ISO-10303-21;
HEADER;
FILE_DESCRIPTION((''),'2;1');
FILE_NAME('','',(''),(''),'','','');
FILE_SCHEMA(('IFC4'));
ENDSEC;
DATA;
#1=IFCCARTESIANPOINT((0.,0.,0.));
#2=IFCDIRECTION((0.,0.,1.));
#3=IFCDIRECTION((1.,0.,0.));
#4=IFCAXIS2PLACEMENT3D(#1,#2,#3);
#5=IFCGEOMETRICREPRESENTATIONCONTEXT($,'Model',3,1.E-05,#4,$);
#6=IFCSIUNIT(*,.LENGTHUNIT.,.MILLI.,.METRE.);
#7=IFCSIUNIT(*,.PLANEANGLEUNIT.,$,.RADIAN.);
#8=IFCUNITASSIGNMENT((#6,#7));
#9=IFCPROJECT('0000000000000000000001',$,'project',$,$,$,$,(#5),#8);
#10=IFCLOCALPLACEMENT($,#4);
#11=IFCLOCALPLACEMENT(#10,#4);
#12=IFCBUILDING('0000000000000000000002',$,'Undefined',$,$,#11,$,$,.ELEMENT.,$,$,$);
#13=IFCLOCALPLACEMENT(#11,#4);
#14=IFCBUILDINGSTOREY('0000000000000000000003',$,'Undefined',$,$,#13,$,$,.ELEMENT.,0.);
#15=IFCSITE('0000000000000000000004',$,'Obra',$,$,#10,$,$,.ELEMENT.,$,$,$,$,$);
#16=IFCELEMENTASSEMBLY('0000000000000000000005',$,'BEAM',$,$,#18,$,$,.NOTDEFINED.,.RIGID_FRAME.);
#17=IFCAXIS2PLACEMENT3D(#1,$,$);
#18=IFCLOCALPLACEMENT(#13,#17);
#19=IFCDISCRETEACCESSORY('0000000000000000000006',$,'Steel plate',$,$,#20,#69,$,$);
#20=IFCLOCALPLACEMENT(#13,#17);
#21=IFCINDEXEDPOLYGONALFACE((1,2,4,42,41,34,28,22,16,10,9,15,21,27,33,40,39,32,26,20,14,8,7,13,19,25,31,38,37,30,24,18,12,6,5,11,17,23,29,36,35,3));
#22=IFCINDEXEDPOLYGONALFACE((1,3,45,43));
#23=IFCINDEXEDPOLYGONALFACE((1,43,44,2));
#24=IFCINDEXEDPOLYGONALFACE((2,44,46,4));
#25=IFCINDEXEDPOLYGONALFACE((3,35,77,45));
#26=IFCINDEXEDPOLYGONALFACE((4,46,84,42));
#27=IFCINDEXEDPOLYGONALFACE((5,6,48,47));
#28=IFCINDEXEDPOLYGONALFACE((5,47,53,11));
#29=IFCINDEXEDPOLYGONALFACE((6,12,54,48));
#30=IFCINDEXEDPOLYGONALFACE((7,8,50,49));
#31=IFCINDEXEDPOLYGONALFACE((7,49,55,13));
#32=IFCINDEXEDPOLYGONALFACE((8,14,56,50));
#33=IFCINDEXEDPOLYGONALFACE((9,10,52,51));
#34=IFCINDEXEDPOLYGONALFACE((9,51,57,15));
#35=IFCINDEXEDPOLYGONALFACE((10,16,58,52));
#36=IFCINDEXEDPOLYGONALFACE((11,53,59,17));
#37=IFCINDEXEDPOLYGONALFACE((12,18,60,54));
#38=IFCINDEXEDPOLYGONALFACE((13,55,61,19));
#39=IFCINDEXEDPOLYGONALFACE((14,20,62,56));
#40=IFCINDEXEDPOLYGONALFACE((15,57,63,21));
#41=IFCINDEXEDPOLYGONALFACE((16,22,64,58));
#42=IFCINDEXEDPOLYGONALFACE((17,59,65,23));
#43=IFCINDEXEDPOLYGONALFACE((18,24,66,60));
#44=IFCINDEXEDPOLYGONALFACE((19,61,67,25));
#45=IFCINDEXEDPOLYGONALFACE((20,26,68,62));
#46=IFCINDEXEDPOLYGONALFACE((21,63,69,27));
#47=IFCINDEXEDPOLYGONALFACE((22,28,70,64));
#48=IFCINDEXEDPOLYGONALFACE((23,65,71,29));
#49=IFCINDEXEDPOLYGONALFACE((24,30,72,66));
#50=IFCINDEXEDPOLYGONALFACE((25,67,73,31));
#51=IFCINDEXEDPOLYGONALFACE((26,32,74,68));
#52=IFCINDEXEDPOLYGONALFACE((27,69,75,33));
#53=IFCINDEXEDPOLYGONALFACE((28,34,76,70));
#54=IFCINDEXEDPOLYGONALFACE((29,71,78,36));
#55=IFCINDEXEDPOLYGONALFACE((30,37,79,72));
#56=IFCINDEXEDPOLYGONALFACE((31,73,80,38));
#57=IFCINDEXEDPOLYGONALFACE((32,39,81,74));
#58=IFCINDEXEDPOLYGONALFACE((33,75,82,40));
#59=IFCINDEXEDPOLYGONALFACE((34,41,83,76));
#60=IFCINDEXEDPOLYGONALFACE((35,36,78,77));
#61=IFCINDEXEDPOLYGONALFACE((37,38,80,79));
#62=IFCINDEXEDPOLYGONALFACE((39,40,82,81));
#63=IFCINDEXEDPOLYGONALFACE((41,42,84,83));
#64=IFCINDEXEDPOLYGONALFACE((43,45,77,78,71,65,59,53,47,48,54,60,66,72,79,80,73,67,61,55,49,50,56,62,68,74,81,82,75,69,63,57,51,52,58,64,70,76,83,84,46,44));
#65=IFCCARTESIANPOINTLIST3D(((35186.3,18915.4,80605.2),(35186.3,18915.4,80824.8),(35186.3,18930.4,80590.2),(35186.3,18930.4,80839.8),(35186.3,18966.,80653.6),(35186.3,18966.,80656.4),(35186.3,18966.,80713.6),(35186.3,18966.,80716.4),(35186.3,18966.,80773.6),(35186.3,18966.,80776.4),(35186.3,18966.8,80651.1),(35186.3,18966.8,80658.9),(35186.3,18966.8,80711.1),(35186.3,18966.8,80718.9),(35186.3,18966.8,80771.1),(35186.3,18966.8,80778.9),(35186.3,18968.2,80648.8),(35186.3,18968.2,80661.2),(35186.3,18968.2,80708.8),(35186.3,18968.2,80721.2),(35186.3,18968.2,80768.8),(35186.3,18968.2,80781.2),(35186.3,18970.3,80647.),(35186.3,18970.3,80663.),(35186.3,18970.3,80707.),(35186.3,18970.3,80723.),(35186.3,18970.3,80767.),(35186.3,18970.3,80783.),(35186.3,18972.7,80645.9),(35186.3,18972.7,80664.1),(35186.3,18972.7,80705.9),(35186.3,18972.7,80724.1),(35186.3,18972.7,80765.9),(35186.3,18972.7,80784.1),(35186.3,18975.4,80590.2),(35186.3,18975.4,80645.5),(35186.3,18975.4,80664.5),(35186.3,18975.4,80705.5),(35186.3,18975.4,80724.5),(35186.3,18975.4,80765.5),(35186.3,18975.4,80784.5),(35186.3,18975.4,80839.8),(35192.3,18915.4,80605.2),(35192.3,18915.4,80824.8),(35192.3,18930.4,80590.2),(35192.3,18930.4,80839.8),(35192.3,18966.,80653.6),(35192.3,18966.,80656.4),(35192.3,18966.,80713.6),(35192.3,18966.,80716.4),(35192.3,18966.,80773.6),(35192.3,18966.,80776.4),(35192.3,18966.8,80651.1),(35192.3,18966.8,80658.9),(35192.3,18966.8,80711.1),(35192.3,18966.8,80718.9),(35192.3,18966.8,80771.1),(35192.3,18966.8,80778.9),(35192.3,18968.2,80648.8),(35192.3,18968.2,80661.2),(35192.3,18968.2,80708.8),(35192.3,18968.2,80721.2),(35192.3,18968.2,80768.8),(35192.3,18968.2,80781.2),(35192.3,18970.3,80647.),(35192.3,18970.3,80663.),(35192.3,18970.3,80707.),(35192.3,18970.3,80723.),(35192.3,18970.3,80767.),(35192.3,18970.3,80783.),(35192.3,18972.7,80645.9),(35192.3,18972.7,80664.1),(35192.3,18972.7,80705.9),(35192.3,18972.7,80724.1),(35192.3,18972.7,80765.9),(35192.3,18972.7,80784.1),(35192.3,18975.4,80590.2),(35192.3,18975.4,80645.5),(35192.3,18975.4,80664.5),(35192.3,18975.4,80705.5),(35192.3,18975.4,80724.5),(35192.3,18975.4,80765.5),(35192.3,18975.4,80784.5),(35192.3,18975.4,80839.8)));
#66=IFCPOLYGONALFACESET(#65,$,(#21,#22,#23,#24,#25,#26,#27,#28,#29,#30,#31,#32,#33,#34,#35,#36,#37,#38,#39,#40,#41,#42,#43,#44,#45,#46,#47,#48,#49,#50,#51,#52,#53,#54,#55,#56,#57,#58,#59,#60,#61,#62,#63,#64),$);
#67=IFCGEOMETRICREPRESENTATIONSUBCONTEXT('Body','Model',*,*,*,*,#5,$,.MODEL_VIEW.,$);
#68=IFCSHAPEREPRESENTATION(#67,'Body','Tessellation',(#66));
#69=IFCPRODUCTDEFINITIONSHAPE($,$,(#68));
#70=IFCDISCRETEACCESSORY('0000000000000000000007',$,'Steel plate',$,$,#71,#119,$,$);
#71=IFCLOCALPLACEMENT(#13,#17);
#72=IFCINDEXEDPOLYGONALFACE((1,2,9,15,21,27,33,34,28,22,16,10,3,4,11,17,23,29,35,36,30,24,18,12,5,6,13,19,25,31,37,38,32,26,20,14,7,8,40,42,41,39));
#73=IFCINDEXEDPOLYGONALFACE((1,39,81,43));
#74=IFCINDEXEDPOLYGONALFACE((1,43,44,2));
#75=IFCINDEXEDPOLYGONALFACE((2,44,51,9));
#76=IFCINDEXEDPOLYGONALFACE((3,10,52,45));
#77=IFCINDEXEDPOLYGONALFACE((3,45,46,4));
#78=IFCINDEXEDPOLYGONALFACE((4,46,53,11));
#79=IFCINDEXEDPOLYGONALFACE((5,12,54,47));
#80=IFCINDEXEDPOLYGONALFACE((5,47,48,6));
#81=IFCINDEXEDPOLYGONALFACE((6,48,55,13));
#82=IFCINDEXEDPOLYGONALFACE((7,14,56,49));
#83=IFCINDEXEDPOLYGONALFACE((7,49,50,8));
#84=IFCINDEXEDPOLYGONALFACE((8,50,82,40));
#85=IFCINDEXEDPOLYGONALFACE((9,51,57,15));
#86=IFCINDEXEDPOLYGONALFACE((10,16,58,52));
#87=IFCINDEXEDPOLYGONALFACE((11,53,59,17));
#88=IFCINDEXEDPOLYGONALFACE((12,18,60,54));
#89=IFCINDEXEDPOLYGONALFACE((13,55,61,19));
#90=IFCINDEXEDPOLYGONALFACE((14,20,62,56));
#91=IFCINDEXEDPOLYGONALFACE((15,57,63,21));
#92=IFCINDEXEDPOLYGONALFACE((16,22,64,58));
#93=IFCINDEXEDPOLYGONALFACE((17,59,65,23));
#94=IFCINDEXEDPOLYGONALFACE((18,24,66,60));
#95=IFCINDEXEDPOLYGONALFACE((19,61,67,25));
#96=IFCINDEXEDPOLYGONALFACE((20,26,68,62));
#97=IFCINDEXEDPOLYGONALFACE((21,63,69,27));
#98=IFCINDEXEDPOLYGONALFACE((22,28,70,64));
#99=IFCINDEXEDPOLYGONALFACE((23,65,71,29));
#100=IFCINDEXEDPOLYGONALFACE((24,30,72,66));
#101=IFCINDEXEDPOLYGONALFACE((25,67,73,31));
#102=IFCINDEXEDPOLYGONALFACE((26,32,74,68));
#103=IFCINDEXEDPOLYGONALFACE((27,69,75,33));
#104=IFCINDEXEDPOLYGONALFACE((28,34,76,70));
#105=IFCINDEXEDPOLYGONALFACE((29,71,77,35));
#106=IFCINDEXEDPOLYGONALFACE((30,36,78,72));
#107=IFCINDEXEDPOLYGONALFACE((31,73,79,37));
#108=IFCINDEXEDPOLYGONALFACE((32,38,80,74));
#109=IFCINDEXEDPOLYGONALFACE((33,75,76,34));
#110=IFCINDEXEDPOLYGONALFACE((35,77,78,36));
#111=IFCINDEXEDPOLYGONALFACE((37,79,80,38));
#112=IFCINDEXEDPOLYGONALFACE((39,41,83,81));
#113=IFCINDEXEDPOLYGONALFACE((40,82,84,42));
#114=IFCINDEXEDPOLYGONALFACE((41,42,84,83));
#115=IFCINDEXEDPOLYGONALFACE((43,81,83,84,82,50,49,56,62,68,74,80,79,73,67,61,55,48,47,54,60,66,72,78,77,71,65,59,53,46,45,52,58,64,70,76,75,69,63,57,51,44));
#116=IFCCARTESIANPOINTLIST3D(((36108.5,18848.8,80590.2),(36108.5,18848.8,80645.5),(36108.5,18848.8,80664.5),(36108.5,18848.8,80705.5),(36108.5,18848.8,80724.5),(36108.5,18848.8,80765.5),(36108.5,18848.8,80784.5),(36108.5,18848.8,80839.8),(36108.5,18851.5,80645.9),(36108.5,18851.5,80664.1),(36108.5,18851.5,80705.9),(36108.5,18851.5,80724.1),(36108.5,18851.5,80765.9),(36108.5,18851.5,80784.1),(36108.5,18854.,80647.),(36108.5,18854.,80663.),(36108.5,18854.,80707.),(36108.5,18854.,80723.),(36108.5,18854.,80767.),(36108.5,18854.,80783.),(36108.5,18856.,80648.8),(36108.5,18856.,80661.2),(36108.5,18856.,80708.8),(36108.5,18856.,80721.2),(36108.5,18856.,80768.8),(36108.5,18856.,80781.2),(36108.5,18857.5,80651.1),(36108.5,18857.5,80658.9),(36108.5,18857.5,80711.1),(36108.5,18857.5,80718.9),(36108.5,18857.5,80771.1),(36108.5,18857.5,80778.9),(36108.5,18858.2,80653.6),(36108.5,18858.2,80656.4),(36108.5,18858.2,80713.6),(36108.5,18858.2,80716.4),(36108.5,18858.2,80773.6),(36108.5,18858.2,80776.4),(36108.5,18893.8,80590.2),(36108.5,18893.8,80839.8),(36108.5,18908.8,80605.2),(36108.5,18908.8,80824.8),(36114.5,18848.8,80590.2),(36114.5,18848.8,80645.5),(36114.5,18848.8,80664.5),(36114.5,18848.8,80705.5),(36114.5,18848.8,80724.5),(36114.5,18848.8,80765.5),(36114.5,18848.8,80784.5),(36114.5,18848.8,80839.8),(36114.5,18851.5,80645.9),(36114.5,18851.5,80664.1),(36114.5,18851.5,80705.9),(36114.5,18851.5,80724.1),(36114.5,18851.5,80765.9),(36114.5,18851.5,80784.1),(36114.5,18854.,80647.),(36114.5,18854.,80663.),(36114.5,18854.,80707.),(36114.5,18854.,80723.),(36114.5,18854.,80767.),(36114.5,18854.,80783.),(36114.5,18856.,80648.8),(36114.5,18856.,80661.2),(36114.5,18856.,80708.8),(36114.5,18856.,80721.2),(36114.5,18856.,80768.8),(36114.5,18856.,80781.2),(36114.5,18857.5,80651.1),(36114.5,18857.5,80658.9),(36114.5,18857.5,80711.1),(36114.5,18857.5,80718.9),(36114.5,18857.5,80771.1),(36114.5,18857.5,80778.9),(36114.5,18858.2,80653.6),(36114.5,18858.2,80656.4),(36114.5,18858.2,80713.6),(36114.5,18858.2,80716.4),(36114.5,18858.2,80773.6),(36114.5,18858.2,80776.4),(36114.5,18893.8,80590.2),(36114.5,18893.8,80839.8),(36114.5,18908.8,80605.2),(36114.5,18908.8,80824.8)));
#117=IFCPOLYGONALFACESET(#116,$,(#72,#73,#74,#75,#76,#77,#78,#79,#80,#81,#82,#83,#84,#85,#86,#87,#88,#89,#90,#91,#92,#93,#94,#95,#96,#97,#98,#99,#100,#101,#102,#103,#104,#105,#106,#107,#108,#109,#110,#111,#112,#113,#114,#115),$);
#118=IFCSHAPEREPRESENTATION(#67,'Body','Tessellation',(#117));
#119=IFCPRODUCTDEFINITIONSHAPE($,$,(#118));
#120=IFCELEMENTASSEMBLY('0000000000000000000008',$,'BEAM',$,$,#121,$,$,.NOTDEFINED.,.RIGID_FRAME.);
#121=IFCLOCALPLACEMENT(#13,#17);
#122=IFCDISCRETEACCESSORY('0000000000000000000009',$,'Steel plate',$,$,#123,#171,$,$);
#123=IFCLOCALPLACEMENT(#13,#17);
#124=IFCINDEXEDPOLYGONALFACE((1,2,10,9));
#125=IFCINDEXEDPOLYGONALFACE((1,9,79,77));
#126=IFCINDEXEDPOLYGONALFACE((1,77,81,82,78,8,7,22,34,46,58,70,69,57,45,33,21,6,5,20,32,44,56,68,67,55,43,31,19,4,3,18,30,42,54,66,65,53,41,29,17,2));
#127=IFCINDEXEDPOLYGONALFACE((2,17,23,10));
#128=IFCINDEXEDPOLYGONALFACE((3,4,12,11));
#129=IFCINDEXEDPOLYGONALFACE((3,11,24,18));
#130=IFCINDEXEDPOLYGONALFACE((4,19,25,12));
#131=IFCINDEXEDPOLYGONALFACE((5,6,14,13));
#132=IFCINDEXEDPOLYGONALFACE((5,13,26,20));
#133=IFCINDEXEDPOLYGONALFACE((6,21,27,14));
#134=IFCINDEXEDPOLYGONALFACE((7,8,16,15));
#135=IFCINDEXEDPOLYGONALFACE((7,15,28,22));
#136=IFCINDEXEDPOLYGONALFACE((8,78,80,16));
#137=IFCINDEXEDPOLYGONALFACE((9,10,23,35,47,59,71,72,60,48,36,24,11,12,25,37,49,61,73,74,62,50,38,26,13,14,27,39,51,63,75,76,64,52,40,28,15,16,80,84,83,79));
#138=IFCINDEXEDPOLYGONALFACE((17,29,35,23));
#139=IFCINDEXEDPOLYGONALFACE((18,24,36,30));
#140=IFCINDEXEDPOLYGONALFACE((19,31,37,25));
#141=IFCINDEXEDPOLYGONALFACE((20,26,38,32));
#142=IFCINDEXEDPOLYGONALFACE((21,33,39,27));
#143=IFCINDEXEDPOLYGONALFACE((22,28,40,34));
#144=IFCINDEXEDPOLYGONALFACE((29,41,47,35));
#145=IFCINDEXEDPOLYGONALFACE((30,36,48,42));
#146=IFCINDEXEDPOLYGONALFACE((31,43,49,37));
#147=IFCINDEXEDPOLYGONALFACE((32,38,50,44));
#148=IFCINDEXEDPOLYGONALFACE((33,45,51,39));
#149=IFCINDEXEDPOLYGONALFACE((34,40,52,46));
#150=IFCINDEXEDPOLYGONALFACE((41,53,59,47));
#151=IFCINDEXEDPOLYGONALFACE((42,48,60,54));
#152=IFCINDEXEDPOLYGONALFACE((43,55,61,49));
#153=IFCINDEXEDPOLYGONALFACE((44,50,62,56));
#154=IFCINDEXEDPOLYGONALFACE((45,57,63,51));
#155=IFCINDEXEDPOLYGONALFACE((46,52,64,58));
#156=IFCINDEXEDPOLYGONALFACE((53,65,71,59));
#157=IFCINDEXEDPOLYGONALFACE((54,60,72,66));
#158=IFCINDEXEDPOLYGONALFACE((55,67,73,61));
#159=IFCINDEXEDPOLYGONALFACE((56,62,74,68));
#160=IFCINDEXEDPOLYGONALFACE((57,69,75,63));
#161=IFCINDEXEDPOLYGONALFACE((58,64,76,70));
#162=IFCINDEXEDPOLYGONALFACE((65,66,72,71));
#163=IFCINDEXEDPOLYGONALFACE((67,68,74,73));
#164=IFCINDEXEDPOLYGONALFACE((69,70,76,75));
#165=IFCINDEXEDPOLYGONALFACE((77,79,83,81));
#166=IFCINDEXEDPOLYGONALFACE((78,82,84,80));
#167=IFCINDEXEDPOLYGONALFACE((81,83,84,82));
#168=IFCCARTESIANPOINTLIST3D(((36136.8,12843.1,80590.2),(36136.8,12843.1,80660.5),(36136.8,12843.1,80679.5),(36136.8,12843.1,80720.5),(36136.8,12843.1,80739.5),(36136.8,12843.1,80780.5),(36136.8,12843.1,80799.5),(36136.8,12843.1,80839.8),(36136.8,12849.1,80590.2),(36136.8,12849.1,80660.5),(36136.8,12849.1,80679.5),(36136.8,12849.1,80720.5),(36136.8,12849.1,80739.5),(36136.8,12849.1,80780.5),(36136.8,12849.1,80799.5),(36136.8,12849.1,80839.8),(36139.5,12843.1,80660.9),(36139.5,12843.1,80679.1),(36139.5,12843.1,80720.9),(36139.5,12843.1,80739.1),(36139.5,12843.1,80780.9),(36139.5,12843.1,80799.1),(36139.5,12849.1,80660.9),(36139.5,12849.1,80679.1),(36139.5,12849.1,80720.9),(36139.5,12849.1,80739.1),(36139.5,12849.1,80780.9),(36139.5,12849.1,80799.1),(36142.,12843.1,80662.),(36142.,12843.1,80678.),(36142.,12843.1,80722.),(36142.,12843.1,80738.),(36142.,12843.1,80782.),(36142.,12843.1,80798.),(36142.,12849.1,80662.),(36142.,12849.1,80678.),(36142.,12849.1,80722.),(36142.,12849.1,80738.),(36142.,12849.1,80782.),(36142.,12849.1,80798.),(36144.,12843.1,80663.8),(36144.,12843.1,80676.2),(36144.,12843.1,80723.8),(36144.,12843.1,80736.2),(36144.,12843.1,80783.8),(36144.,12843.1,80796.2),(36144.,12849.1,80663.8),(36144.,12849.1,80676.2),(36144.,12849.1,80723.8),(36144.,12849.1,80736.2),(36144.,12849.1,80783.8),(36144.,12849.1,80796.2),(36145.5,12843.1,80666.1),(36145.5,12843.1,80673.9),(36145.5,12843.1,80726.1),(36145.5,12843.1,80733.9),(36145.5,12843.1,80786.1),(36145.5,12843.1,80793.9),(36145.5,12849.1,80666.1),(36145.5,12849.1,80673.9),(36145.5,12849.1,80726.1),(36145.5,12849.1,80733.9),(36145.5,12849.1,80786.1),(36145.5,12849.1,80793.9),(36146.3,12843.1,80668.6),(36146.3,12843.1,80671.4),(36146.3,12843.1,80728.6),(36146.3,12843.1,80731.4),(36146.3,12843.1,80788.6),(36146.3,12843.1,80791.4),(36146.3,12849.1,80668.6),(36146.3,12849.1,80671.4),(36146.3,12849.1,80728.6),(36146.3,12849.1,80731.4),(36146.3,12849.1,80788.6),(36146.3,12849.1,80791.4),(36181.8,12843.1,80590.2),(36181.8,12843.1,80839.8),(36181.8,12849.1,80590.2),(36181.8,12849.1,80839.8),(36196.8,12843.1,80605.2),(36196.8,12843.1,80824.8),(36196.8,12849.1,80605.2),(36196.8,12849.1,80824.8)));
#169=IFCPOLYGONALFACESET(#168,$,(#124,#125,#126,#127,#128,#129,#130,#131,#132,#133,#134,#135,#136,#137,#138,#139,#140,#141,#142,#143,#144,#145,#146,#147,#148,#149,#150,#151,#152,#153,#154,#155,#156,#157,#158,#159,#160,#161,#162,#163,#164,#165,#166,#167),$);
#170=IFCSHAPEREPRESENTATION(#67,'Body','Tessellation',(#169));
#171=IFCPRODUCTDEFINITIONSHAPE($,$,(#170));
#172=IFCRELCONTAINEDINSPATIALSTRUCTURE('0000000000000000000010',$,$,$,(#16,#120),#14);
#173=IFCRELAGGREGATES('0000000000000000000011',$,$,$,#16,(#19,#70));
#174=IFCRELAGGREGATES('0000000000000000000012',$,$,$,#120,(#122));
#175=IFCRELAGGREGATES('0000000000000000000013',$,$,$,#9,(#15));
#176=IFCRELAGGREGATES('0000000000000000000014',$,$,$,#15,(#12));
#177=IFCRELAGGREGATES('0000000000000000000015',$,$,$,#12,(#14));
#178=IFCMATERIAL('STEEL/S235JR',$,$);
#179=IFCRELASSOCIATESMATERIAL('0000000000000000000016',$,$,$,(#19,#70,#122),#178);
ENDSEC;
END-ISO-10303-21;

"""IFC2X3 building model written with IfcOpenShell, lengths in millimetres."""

from ifc_helpers import new_model, si_unit, frame, origin_with_axes, origin_2d_with_axis, place, context, subcontext, project, spatial, polyline, circle, outline, extrude, source, transform, mapped, material, element, aggregate, save


model = new_model("IFC2X3")

# Units and contexts
model_context = context("Model", 3, precision=1e-05, world=origin_with_axes())
body_context = subcontext(model_context, "Body", "Model", "MODEL_VIEW")
ifc_project = project(units=[si_unit("LENGTHUNIT", "METRE", prefix="MILLI"), si_unit("PLANEANGLEUNIT", "RADIAN")], contexts=[model_context])

# Site, building, storey
site_placement = place(None, origin_with_axes())
site = spatial("IfcSite", under=ifc_project, at=site_placement, Name="Obra", CompositionType="ELEMENT")
building_placement = place(site_placement, origin_with_axes())
building = spatial("IfcBuilding", under=site, at=building_placement, Name="Undefined", CompositionType="ELEMENT")
storey_placement = place(building_placement, origin_with_axes())
storey = spatial("IfcBuildingStorey", under=building, at=storey_placement, Name="Undefined", CompositionType="ELEMENT", Elevation=0.0)

# Element assembly
ifc_material_1 = material(Name="STEEL/S235JR")
assembly_1_placement = place(storey_placement, origin_with_axes())
assembly_1 = element("IfcElementAssembly", 1, at=assembly_1_placement, inside=storey, Name="BEAM", AssemblyPlace="NOTDEFINED", PredefinedType="RIGID_FRAME")

# Discrete accessories, openings
discrete_accessory_1_placement = place(assembly_1_placement, frame((35189.3, 18975.4, 80590.2), z_axis=(-1.0, 0.0, 0.0), x_axis=(0.0, -1.0, 0.0)))
discrete_accessory_1 = element("IfcDiscreteAccessory", 2, at=discrete_accessory_1_placement, material=ifc_material_1, Name="Steel plate", context=body_context, shape_type="SweptSolid", body=[
    extrude(outline(polyline([(0.0, 0.0), (45.0, 0.0), (60.0, 15.0), (60.0, 234.6), (45.0, 249.6), (0.0, 249.6), (0.0, 0.0)])), frame((0.0, 0.0, -3.0), z_axis=(0.0, 0.0, 1.0), x_axis=(1.0, 0.0, 0.0)), (0.0, 0.0, 1.0), 6.0),
])
shared_shape_1 = source(origin_with_axes(), body_context, "Body", "SweptSolid", [
    extrude(circle(Radius=9.5, at=origin_2d_with_axis()), frame((0.0, -9.4, 0.0), z_axis=(0.0, 1.0, 0.0), x_axis=(1.0, 0.0, 0.0)), (0.0, 0.0, 1.0), 6.2),
])
opening_1_placement = place(assembly_1_placement, frame((35183.0, 18925.4, 80850.0), z_axis=(0.0, 1.0, 0.0), x_axis=(0.0, 0.0, -1.0)))
element("IfcOpeningElement", 3, at=opening_1_placement, cuts=discrete_accessory_1, ObjectType="Opening", context=body_context, shape_type="MappedRepresentation", body=[
    mapped(shared_shape_1, transform((75.0, 0.0, 50.0))),
    mapped(shared_shape_1, transform((135.0, 0.0, 50.0))),
    mapped(shared_shape_1, transform((195.0, 0.0, 50.0))),
])
discrete_accessory_2_placement = place(assembly_1_placement, frame((36111.5, 18848.8, 80590.2), z_axis=(1.0, 0.0, 0.0), x_axis=(0.0, 1.0, 0.0)))
discrete_accessory_2 = element("IfcDiscreteAccessory", 4, at=discrete_accessory_2_placement, material=ifc_material_1, Name="Steel plate", context=body_context, shape_type="SweptSolid", body=[
    extrude(outline(polyline([(0.0, 0.0), (45.0, 0.0), (60.0, 15.0), (60.0, 234.6), (45.0, 249.6), (0.0, 249.6), (0.0, 0.0)])), frame((0.0, 0.0, -3.0), z_axis=(0.0, 0.0, 1.0), x_axis=(1.0, 0.0, 0.0)), (0.0, 0.0, 1.0), 6.0),
])
opening_2_placement = place(assembly_1_placement, frame((36117.8, 18898.8, 80850.0), z_axis=(0.0, -1.0, 0.0), x_axis=(0.0, 0.0, -1.0)))
element("IfcOpeningElement", 5, at=opening_2_placement, cuts=discrete_accessory_2, ObjectType="Opening", context=body_context, shape_type="MappedRepresentation", body=[
    mapped(shared_shape_1, transform((75.0, 0.0, 50.0))),
    mapped(shared_shape_1, transform((135.0, 0.0, 50.0))),
    mapped(shared_shape_1, transform((195.0, 0.0, 50.0))),
])
aggregate(assembly_1, [discrete_accessory_1, discrete_accessory_2])

# Element assembly, discrete accessory, opening
assembly_2_placement = place(storey_placement, origin_with_axes())
assembly_2 = element("IfcElementAssembly", 6, at=assembly_2_placement, inside=storey, Name="BEAM", AssemblyPlace="NOTDEFINED", PredefinedType="RIGID_FRAME")
discrete_accessory_3_placement = place(assembly_2_placement, frame((36136.8, 12846.1, 80590.2), z_axis=(0.0, -1.0, 0.0), x_axis=(1.0, 0.0, 0.0)))
discrete_accessory_3 = element("IfcDiscreteAccessory", 7, at=discrete_accessory_3_placement, material=ifc_material_1, Name="Steel plate", context=body_context, shape_type="SweptSolid", body=[
    extrude(outline(polyline([(0.0, 0.0), (45.0, 0.0), (60.0, 15.0), (60.0, 234.6), (45.0, 249.6), (0.0, 249.6), (0.0, 0.0)])), frame((0.0, 0.0, -3.0), z_axis=(0.0, 0.0, 1.0), x_axis=(1.0, 0.0, 0.0)), (0.0, 0.0, 1.0), 6.0),
])
shared_shape_2 = source(origin_with_axes(), body_context, "Body", "SweptSolid", [
    extrude(circle(Radius=9.5, at=origin_2d_with_axis()), frame((0.0, -9.2, 0.0), z_axis=(0.0, 1.0, 0.0), x_axis=(1.0, 0.0, 0.0)), (0.0, 0.0, 1.0), 6.2),
])
opening_3_placement = place(assembly_2_placement, frame((36186.8, 12840.0, 80850.0), z_axis=(-1.0, 0.0, 0.0), x_axis=(0.0, 0.0, -1.0)))
element("IfcOpeningElement", 8, at=opening_3_placement, cuts=discrete_accessory_3, ObjectType="Opening", context=body_context, shape_type="MappedRepresentation", body=[
    mapped(shared_shape_2, transform((60.0, 0.0, 50.0))),
    mapped(shared_shape_2, transform((120.0, 0.0, 50.0))),
    mapped(shared_shape_2, transform((180.0, 0.0, 50.0))),
])
aggregate(assembly_2, [discrete_accessory_3])

save(model, "model.ifc")
